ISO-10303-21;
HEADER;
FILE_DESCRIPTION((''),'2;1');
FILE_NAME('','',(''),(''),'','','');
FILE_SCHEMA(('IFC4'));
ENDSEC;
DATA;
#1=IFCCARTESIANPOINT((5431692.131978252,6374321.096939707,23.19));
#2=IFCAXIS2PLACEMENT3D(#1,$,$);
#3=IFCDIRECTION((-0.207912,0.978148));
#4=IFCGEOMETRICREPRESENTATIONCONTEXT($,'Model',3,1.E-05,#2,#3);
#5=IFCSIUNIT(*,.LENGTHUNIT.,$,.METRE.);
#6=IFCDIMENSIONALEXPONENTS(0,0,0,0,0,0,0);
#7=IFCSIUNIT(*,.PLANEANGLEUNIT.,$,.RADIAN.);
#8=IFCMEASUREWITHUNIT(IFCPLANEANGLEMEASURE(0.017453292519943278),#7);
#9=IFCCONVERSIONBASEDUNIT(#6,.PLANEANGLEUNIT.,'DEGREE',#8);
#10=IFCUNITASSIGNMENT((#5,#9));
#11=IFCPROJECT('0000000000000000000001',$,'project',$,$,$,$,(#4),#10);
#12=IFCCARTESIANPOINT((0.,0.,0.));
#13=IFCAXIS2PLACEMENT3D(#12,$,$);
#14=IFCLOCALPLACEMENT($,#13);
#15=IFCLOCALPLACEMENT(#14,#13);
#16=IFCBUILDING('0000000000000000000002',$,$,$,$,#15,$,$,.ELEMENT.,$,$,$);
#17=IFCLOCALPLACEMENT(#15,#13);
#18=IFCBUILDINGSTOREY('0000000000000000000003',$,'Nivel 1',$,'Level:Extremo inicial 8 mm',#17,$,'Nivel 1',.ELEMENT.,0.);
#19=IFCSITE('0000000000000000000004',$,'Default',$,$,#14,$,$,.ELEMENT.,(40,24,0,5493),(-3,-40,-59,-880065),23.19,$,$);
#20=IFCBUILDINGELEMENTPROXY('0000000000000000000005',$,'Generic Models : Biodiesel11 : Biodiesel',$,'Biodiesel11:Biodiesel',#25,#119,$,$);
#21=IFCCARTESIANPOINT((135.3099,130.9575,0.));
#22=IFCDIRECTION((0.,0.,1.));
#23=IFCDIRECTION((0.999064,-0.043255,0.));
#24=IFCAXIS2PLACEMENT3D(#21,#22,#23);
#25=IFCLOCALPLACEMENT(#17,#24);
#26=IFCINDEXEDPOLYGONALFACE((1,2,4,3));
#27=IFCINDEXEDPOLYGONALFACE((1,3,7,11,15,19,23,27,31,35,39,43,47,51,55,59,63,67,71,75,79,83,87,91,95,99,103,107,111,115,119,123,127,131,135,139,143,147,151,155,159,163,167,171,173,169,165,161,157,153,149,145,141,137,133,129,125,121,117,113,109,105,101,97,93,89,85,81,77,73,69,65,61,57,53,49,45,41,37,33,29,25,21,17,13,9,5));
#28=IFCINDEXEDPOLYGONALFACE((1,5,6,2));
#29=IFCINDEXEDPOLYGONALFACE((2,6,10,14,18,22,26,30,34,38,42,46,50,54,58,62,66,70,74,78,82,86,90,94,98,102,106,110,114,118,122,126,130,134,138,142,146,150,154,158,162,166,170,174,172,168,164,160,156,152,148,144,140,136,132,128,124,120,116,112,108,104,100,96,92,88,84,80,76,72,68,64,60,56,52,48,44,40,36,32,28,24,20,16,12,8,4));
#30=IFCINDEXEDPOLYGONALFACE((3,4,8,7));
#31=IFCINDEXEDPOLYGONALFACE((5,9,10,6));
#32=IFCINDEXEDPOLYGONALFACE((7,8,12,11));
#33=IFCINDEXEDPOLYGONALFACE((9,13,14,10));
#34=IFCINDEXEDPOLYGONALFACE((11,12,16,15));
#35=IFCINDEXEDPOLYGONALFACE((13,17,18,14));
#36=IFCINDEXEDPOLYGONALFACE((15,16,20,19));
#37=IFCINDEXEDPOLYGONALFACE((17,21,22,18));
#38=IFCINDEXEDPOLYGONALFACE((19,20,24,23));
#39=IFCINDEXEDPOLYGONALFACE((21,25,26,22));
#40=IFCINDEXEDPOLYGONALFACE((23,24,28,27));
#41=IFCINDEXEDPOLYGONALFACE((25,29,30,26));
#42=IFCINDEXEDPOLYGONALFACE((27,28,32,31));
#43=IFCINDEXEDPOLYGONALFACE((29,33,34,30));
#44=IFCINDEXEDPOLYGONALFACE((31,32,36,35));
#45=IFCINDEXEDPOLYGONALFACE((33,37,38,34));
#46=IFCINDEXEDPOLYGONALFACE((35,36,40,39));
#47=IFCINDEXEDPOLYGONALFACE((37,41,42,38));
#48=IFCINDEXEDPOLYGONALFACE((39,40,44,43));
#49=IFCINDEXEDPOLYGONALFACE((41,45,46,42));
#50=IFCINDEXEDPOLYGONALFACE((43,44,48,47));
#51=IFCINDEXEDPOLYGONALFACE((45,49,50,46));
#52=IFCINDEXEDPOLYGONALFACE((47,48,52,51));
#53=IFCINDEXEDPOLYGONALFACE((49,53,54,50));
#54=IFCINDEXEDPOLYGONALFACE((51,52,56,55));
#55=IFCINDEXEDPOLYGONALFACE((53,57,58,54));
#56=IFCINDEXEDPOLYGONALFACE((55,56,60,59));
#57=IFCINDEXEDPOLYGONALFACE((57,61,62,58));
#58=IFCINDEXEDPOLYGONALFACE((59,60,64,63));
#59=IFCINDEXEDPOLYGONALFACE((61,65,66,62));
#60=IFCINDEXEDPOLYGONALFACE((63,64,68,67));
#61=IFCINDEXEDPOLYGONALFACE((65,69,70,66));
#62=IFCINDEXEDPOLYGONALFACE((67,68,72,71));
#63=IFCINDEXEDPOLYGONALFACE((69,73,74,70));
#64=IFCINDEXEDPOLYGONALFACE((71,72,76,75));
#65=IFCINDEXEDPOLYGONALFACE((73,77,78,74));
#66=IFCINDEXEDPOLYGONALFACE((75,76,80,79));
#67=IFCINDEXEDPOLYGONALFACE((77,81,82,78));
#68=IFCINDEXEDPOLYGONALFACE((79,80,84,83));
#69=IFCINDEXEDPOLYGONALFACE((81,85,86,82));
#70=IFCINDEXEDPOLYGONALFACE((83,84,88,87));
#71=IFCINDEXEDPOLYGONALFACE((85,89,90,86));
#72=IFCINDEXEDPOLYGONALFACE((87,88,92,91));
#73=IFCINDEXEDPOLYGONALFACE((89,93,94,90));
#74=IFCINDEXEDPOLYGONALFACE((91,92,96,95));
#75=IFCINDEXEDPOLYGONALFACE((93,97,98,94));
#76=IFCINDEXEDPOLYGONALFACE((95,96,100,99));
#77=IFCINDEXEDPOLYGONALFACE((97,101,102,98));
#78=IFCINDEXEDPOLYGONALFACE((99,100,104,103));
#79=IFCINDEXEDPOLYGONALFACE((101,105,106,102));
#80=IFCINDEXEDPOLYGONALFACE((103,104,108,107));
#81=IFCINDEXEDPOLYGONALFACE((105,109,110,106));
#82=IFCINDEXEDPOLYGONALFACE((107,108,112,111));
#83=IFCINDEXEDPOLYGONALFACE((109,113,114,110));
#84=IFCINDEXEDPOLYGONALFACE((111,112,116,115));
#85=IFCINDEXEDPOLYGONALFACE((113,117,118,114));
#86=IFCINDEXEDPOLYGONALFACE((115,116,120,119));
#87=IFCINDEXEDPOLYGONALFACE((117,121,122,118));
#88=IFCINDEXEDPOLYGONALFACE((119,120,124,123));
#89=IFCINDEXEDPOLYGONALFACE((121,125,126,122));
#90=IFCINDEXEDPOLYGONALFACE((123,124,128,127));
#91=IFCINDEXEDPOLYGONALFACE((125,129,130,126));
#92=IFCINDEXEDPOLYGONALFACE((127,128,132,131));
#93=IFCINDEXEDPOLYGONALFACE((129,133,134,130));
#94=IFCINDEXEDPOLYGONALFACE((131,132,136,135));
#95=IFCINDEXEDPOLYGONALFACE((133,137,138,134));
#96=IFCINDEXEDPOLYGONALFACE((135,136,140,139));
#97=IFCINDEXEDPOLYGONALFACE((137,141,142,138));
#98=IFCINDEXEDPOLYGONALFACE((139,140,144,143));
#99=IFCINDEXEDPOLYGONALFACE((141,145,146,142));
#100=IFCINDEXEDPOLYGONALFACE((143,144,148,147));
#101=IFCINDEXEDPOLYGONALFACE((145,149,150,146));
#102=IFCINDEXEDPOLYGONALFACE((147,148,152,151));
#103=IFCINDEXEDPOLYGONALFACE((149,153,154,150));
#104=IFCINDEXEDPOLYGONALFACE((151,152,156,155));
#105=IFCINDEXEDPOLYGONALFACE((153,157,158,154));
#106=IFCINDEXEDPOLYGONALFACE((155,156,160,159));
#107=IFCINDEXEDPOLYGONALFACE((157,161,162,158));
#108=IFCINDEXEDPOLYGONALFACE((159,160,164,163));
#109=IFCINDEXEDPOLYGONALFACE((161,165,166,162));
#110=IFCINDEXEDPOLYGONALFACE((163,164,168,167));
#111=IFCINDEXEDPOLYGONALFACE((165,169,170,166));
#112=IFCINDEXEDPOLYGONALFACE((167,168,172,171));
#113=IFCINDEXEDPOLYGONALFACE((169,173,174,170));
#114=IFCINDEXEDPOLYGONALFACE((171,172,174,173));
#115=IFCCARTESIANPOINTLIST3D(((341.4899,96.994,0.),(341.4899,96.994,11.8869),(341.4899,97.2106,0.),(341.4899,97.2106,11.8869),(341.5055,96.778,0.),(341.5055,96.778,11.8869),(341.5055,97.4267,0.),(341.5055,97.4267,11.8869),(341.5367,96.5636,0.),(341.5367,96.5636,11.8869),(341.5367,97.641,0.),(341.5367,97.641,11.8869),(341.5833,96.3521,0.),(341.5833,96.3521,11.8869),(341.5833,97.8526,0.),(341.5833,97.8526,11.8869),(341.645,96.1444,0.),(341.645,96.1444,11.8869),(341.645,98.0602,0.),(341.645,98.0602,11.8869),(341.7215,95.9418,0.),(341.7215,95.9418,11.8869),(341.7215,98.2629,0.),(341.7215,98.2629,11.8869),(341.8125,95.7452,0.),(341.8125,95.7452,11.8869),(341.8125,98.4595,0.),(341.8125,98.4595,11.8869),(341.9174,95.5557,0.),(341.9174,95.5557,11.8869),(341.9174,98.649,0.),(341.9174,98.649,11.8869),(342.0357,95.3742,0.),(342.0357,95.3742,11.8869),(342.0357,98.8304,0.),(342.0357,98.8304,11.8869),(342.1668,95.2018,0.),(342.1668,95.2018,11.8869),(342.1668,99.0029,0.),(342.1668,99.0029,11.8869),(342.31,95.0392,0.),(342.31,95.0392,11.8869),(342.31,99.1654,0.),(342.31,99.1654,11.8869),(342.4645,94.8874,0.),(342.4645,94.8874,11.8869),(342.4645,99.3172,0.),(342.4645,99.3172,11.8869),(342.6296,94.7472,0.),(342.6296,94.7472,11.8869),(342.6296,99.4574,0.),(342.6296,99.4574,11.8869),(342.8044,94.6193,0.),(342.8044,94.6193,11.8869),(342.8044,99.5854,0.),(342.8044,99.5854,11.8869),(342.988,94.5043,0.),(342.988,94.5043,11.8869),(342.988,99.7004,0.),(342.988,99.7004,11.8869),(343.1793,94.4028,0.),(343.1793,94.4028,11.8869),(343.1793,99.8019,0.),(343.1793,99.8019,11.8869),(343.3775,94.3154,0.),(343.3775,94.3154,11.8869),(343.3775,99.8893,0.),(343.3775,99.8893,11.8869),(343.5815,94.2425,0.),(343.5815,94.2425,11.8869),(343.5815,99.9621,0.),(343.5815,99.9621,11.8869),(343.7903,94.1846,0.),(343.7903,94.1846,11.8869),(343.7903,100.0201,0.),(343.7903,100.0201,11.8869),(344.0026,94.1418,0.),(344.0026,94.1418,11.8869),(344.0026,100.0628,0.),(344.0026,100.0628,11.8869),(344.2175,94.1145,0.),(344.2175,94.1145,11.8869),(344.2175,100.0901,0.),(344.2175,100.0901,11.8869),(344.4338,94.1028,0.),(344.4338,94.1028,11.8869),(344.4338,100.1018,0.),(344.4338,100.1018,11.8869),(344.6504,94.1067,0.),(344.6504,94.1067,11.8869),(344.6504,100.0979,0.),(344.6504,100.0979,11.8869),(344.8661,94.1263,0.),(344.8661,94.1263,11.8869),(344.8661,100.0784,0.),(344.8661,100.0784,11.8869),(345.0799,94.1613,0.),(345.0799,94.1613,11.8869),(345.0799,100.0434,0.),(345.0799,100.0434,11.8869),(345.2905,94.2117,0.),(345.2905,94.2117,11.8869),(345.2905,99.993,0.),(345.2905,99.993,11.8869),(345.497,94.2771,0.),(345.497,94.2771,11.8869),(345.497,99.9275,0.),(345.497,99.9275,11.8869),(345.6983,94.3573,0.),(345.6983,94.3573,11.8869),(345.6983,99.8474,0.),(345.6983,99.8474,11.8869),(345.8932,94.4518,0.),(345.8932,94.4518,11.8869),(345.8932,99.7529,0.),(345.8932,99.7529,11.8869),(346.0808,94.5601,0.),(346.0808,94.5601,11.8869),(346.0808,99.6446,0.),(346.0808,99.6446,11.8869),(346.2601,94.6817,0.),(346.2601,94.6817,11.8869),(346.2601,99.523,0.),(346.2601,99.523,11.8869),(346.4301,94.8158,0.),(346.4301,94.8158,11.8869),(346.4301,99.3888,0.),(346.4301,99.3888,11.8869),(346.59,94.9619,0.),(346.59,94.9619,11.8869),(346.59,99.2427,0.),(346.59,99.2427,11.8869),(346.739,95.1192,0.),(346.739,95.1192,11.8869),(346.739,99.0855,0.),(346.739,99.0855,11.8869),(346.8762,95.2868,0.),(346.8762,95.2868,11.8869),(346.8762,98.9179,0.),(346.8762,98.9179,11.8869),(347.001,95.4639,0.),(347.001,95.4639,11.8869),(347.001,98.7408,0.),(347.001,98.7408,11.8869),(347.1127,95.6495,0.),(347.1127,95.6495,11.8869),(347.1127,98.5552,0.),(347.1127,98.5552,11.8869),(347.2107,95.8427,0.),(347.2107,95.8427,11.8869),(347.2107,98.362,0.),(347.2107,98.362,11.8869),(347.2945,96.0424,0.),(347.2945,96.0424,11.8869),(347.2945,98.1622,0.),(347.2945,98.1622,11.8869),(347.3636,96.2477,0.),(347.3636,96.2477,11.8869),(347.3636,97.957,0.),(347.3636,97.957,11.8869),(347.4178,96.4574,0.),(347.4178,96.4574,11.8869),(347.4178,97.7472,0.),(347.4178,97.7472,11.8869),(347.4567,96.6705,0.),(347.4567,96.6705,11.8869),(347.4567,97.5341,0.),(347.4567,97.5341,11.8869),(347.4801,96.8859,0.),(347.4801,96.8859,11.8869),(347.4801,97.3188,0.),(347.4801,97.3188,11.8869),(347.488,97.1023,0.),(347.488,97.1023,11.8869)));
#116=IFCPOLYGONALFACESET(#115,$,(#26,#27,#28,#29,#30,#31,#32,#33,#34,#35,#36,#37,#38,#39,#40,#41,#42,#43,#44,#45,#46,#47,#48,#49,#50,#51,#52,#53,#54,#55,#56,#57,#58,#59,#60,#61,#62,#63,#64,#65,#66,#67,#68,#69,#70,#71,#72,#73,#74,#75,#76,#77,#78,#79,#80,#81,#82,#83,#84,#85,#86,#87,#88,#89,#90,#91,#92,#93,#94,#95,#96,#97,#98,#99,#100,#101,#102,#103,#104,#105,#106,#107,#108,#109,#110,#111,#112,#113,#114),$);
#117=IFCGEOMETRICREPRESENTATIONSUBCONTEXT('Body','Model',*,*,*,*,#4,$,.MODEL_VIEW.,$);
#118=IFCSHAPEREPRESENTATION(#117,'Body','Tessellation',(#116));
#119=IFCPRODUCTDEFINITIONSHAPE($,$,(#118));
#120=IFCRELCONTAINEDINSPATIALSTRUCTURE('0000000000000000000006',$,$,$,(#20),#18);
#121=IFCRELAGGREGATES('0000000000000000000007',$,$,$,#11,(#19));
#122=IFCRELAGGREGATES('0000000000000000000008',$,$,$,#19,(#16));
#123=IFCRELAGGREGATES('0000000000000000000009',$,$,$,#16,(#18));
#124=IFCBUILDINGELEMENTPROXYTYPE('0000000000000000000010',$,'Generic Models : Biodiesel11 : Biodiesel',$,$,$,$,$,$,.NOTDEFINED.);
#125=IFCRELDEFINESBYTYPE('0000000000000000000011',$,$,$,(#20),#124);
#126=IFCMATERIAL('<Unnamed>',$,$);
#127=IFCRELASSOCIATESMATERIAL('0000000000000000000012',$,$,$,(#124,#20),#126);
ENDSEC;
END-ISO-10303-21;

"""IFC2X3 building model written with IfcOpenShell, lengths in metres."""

from ifc_helpers import new_model, entity, si_unit, converted_unit, direction, frame, frame_2d, origin, place, context, subcontext, project, spatial, circle, extrude, source, transform, mapped, material, type_object, type_shapes, element, save


model = new_model("IFC2X3")

# Units and contexts
model_context = context("Model", 3, precision=1e-05, world=frame((5431692.131978252, 6374321.096939707, 23.19)), true_north=direction((-0.207912, 0.978148)))
body_context = subcontext(model_context, "Body", "Model", "MODEL_VIEW")
ifc_project = project(units=[si_unit("LENGTHUNIT", "METRE"), converted_unit("PLANEANGLEUNIT", "DEGREE", entity("IfcPlaneAngleMeasure", 0.017453292519943278), si_unit("PLANEANGLEUNIT", "RADIAN"), dimensions=[0, 0, 0, 0, 0, 0, 0])], contexts=[model_context])

# Site, building, storey
site_placement = place(None, origin())
site = spatial("IfcSite", under=ifc_project, at=site_placement, Name="Default", CompositionType="ELEMENT", RefLatitude=(40, 24, 0, 5493), RefLongitude=(-3, -40, -59, -880065), RefElevation=23.19)
building_placement = place(site_placement, origin())
building = spatial("IfcBuilding", under=site, at=building_placement, CompositionType="ELEMENT")
storey_placement = place(building_placement, origin())
storey = spatial("IfcBuildingStorey", under=building, at=storey_placement, Name="Nivel 1", ObjectType="Level:Extremo inicial 8 mm", LongName="Nivel 1", CompositionType="ELEMENT", Elevation=0.0)

# Building element proxy
ifc_material_1 = material(Name="<Unnamed>")
building_element_proxy_type_1 = type_object("IfcBuildingElementProxyType", Name="Generic Models : Biodiesel11 : Biodiesel", PredefinedType="NOTDEFINED", material=ifc_material_1)
shared_shape_1 = source(origin(), body_context, "Body", "SweptSolid", [
    extrude(circle(Radius=3.0, at=frame_2d((0.0, 0.0), x_axis=(1.0, 0.0))), frame((344.488, 97.1023, 0.0)), (0.0, 0.0, 1.0), 11.8869),
])
type_shapes(building_element_proxy_type_1, [shared_shape_1])
proxy_1_placement = place(storey_placement, frame((135.3099, 130.9575, 0.0), z_axis=(0.0, 0.0, 1.0), x_axis=(0.999064, -0.043255, 0.0)))
element("IfcBuildingElementProxy", 1, at=proxy_1_placement, inside=storey, type_object=building_element_proxy_type_1, material=ifc_material_1, Name="Generic Models : Biodiesel11 : Biodiesel", ObjectType="Biodiesel11:Biodiesel", context=body_context, shape_type="MappedRepresentation", body=[
    mapped(shared_shape_1, transform((0.0, 0.0, 0.0), scale=1.0)),
])

save(model, "model.ifc")
